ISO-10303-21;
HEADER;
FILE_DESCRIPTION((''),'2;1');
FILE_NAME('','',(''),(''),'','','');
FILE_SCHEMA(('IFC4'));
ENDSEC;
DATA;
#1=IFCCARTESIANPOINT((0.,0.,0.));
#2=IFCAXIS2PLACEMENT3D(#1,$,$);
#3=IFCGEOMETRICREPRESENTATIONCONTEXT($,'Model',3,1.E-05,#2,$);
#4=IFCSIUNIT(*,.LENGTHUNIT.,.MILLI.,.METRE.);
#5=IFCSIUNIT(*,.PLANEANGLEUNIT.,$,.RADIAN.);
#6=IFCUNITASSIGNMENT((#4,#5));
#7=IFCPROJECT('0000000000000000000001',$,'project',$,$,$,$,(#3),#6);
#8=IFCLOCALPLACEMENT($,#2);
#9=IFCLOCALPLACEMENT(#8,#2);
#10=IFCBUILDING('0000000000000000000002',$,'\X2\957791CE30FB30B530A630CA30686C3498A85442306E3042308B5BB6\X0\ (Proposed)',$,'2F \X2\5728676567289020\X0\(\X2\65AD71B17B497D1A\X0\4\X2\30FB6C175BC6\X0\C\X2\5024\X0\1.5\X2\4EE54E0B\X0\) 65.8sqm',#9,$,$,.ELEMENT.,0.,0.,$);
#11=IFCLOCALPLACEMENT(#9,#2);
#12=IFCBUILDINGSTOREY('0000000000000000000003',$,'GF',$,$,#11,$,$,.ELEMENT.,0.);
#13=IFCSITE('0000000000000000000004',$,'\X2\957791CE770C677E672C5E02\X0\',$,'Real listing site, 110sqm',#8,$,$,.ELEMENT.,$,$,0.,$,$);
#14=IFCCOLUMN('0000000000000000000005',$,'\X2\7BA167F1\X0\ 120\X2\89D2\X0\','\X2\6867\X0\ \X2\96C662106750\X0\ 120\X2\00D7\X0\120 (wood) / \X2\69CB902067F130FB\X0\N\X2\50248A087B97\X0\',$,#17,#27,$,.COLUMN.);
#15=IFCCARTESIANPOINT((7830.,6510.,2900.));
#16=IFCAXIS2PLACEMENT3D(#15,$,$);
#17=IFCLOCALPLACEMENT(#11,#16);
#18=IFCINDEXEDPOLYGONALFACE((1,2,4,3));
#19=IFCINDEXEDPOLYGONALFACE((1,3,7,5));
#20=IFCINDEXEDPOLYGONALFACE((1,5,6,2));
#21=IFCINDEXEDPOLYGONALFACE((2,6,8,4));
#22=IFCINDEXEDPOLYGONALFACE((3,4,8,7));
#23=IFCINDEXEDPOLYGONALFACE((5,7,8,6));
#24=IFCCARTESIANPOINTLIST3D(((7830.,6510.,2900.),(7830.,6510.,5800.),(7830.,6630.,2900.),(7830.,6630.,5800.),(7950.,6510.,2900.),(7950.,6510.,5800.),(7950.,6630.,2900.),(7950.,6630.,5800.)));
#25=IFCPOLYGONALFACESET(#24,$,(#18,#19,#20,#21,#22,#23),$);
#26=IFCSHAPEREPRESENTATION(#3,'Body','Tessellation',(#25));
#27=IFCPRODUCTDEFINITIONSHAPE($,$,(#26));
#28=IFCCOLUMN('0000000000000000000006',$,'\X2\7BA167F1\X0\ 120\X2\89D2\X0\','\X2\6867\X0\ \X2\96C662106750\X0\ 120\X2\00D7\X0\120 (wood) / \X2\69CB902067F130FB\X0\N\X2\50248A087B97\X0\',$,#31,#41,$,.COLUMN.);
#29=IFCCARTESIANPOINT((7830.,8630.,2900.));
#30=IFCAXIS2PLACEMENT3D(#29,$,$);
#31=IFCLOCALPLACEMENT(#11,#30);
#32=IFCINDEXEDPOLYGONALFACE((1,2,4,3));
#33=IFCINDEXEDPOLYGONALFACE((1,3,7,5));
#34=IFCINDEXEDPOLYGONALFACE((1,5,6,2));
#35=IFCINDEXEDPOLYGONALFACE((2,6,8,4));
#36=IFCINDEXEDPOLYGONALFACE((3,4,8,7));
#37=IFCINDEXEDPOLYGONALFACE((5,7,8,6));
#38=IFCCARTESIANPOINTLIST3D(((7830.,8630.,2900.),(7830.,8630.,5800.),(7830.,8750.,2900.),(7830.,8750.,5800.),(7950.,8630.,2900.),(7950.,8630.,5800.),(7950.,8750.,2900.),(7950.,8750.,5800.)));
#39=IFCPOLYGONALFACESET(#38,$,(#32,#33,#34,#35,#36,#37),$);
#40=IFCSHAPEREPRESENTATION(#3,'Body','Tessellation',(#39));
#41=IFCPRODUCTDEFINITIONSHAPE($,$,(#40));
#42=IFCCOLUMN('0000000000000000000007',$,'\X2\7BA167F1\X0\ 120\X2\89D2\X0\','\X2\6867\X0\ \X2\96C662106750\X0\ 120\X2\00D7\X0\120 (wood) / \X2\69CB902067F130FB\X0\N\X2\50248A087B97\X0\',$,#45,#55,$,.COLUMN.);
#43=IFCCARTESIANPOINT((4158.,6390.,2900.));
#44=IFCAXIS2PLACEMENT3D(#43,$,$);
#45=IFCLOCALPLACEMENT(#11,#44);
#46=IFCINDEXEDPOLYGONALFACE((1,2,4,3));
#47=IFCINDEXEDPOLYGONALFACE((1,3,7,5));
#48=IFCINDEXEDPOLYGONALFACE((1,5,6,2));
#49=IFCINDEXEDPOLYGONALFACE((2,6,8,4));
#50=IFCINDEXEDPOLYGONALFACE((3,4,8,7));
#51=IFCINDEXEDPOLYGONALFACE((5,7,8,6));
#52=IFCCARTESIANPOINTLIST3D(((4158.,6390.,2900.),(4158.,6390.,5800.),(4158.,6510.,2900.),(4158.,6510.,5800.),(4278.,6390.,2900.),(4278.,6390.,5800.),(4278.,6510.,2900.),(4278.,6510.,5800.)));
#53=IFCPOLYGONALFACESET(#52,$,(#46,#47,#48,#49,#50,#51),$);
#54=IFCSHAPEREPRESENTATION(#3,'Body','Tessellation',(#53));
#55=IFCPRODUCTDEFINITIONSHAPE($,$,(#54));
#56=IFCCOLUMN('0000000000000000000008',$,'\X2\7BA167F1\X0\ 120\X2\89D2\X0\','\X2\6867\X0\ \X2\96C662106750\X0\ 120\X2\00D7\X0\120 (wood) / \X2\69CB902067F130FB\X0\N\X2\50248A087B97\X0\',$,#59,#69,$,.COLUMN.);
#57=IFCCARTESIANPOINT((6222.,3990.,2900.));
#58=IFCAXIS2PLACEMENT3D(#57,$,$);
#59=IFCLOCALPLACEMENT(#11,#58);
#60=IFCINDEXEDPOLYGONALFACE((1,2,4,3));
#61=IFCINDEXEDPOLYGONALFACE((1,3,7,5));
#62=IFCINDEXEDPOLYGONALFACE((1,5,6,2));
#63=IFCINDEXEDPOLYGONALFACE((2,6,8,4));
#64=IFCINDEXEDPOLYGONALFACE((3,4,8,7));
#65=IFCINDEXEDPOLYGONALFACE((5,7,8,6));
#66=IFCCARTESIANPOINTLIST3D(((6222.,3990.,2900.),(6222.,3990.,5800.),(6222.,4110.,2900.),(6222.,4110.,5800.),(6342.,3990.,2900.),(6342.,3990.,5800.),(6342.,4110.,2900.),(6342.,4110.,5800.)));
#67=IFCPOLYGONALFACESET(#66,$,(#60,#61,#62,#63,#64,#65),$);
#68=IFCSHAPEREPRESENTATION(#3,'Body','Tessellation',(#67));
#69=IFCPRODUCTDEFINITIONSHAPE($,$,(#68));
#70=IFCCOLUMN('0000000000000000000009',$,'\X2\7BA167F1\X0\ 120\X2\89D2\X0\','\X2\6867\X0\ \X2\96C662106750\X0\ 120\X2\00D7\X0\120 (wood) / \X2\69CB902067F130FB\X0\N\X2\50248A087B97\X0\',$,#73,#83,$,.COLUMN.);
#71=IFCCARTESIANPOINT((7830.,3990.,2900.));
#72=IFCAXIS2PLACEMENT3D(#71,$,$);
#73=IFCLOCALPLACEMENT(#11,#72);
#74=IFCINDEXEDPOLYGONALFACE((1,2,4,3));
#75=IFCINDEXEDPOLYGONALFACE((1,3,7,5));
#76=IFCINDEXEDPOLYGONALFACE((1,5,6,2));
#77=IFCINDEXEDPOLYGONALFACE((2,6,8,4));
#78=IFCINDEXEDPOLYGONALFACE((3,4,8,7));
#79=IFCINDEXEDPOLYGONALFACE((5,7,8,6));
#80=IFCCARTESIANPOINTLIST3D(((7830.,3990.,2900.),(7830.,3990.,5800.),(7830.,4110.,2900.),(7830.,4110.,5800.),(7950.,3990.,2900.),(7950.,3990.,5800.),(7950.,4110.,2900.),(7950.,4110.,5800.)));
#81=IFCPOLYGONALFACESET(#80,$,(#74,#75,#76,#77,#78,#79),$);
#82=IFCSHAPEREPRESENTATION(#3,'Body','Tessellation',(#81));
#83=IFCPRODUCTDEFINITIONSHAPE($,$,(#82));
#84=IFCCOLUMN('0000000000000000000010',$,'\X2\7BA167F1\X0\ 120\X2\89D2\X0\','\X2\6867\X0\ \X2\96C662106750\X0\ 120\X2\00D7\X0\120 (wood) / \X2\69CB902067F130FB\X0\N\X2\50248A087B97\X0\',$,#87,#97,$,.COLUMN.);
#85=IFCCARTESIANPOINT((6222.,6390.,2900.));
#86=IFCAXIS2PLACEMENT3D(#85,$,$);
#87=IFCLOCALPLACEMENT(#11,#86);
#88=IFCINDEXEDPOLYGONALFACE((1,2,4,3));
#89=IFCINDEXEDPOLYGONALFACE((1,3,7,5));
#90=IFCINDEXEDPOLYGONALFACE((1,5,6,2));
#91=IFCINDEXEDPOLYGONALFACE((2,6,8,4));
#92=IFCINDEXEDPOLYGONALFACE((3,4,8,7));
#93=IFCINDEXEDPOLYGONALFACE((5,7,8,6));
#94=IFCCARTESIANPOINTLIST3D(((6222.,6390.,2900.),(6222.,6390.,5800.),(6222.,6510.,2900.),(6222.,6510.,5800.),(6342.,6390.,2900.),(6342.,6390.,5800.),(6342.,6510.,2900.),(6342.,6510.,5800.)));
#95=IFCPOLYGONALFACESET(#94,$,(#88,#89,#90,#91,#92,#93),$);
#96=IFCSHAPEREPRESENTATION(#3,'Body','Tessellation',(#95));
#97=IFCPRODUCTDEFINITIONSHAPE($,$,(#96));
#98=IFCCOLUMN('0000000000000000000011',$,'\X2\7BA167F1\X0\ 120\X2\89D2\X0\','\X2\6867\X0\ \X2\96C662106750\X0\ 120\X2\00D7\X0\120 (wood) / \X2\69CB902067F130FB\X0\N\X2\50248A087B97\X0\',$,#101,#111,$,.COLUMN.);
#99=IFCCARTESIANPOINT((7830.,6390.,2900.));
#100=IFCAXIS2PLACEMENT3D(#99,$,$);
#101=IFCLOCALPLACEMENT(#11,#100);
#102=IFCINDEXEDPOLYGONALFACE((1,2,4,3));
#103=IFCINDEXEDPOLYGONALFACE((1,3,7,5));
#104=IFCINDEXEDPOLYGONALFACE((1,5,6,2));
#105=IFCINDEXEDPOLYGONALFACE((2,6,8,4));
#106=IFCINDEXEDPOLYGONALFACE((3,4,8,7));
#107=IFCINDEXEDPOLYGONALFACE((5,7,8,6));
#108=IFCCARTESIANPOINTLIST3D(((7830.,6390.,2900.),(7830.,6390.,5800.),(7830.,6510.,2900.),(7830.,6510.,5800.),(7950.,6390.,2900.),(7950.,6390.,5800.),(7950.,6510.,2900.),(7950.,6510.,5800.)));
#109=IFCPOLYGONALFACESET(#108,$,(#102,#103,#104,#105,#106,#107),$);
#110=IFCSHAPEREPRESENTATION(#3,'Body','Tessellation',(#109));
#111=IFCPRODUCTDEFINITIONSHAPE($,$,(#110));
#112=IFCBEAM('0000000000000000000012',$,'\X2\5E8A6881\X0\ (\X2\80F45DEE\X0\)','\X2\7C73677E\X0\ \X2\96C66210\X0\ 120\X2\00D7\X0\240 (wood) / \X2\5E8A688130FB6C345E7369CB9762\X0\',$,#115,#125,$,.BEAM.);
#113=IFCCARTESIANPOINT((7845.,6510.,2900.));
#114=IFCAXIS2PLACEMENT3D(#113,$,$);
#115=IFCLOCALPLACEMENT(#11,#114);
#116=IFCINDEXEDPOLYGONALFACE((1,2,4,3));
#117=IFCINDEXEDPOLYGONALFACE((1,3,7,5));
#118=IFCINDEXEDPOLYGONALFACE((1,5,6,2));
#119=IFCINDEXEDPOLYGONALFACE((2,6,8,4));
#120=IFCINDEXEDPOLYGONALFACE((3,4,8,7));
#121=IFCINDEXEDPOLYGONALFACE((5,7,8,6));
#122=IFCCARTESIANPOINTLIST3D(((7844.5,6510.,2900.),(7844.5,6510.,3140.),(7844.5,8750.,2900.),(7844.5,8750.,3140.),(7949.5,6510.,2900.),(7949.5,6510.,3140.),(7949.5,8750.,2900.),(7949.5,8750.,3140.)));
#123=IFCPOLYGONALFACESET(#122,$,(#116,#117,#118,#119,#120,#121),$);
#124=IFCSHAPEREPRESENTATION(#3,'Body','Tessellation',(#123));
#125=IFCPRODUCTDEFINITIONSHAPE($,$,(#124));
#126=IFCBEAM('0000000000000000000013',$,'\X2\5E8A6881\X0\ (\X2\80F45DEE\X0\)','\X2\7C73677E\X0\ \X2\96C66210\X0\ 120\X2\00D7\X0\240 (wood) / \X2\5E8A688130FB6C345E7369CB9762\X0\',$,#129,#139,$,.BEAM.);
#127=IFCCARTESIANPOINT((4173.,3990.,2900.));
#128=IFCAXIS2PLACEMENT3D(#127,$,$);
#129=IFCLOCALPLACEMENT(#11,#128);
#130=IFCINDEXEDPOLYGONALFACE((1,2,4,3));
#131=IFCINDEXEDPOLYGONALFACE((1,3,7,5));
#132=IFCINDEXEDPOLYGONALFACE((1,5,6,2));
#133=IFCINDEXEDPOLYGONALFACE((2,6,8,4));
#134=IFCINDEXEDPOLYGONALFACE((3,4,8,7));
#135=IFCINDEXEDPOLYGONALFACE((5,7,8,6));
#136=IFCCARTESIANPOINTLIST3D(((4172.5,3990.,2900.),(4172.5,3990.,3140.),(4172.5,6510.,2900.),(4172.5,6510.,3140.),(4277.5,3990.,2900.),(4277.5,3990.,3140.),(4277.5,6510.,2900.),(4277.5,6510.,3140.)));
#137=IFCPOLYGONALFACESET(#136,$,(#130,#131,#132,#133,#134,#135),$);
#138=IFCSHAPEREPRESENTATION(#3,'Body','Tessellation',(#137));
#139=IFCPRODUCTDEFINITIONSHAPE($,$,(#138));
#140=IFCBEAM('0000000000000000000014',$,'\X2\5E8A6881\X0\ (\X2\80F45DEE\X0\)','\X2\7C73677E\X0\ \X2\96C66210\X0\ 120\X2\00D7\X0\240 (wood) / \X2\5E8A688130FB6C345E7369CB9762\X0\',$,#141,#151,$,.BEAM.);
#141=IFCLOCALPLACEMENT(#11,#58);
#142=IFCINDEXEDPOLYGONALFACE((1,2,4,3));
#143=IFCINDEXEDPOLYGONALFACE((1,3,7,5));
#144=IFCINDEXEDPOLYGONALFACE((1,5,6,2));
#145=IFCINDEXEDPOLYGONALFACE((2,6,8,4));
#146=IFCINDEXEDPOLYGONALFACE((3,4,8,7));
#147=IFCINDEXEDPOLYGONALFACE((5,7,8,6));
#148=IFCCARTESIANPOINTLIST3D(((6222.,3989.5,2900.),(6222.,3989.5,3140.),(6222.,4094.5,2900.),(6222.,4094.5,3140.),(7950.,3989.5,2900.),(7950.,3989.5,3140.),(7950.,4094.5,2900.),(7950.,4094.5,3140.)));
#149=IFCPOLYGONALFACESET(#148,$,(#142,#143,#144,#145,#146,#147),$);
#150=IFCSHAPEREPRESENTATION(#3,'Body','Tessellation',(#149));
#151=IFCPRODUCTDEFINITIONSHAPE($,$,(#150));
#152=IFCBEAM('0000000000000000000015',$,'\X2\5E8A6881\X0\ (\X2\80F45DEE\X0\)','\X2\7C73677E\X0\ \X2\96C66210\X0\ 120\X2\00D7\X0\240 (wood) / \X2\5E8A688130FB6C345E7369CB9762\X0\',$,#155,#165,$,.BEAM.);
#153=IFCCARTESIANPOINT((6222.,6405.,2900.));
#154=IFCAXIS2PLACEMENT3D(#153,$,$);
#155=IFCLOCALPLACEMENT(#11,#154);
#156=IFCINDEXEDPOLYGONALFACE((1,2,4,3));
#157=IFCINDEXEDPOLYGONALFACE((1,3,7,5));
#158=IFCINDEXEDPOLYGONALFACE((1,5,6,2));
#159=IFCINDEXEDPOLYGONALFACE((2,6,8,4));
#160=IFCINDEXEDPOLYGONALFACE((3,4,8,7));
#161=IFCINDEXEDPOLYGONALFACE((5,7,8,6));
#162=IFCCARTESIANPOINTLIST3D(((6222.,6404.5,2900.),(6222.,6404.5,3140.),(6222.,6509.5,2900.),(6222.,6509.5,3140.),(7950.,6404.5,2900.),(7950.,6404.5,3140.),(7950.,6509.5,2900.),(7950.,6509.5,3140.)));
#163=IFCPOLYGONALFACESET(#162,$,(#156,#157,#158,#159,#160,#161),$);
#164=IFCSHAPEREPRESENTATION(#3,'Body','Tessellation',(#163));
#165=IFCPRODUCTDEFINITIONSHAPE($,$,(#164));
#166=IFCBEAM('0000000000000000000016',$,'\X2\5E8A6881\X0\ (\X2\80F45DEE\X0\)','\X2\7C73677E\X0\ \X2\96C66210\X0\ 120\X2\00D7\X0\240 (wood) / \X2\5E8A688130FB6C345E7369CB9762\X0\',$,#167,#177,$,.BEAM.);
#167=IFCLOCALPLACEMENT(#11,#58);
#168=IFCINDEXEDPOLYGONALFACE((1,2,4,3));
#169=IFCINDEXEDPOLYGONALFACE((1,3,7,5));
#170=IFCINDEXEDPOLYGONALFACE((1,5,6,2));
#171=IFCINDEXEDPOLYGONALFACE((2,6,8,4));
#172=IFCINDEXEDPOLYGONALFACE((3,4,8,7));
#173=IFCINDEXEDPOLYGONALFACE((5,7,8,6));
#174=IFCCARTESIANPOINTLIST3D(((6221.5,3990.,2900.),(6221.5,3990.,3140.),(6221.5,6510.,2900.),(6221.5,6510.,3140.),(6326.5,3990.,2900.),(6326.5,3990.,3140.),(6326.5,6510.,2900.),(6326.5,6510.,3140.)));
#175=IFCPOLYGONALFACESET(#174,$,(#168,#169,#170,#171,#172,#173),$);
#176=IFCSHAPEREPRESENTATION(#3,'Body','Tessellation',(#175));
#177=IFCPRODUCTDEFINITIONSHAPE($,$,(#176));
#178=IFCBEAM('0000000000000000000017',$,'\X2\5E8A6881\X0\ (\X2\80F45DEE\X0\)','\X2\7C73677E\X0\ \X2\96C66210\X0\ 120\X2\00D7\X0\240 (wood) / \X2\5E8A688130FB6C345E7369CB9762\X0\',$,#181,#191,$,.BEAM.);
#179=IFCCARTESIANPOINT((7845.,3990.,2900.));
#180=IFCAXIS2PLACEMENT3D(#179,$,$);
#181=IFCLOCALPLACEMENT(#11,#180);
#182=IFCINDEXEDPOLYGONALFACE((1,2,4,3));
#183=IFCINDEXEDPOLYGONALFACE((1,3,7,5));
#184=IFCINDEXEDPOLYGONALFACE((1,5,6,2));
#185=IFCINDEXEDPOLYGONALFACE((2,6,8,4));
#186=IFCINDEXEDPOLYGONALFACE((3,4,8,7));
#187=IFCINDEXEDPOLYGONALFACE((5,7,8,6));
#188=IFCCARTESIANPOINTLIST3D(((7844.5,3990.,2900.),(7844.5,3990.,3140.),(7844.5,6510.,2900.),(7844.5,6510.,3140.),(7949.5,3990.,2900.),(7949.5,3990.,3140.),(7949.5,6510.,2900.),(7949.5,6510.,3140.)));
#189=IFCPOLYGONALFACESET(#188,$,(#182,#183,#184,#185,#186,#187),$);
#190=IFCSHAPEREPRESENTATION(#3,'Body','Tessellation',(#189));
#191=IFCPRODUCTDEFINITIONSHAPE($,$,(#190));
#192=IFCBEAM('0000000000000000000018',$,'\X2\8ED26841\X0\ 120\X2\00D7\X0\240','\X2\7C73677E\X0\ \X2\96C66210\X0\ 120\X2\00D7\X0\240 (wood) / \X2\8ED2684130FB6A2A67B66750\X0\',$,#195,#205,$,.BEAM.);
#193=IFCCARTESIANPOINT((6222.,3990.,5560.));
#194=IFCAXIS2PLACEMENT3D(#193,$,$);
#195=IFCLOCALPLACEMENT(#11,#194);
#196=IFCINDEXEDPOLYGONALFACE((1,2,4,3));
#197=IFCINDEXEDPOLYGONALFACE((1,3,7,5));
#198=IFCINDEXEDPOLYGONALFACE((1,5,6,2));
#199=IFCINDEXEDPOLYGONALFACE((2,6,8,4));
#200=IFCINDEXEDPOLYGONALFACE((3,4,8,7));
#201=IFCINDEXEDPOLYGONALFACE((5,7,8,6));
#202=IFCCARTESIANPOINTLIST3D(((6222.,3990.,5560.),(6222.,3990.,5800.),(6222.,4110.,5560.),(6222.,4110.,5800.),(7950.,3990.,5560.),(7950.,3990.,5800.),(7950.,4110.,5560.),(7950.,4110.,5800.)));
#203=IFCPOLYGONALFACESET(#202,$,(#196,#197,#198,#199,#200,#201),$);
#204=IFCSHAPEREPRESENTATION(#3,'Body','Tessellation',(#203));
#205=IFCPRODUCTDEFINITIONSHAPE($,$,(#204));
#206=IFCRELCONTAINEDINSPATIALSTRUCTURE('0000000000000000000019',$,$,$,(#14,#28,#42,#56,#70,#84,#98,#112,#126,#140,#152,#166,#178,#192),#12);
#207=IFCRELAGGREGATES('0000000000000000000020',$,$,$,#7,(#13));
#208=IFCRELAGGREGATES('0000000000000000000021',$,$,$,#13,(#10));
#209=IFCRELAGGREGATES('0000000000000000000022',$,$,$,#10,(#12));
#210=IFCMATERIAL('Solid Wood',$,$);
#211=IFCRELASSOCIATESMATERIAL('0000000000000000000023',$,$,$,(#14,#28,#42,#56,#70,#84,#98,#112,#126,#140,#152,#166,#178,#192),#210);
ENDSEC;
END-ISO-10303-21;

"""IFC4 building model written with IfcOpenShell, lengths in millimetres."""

from ifc_helpers import new_model, si_unit, frame, frame_2d, origin, place, context, project, spatial, rectangle, extrude, material, element, save


model = new_model("IFC4")

# Units and contexts
model_context = context("Model", 3, precision=1e-05, world=origin())
ifc_project = project(units=[si_unit("LENGTHUNIT", "METRE", prefix="MILLI"), si_unit("PLANEANGLEUNIT", "RADIAN")], contexts=[model_context])

# Site, building, storey
site_placement = place(None, origin())
site = spatial("IfcSite", under=ifc_project, at=site_placement, Name="長野県松本市", ObjectType="Real listing site, 110sqm", CompositionType="ELEMENT", RefElevation=0.0)
building_placement = place(site_placement, origin())
building = spatial("IfcBuilding", under=site, at=building_placement, Name="長野・サウナと水風呂のある家 (Proposed)", ObjectType="2F 在来木造(断熱等級4・気密C値1.5以下) 65.8sqm", CompositionType="ELEMENT", ElevationOfRefHeight=0.0, ElevationOfTerrain=0.0)
storey_placement = place(building_placement, origin())
storey = spatial("IfcBuildingStorey", under=building, at=storey_placement, Name="GF", CompositionType="ELEMENT", Elevation=0.0)

# Columns
ifc_material_1 = material(Name="Solid Wood")
column_1_placement = place(storey_placement, frame((7830.0, 6510.0, 2900.0)))
element("IfcColumn", 1, at=column_1_placement, inside=storey, material=ifc_material_1, Name="管柱 120角", Description="桧 集成材 120×120 (wood) / 構造柱・N値計算", PredefinedType="COLUMN", context=model_context, shape_type="SweptSolid", body=[
    extrude(rectangle(XDim=120.0, YDim=120.0, at=frame_2d((60.0, 60.0))), frame((7830.0, 6510.0, 2900.0)), (0.0, 0.0, 1.0), 2900.0),
])
column_2_placement = place(storey_placement, frame((7830.0, 8630.0, 2900.0)))
element("IfcColumn", 2, at=column_2_placement, inside=storey, material=ifc_material_1, Name="管柱 120角", Description="桧 集成材 120×120 (wood) / 構造柱・N値計算", PredefinedType="COLUMN", context=model_context, shape_type="SweptSolid", body=[
    extrude(rectangle(XDim=120.0, YDim=120.0, at=frame_2d((60.0, 60.0))), frame((7830.0, 8630.0, 2900.0)), (0.0, 0.0, 1.0), 2900.0),
])
column_3_placement = place(storey_placement, frame((4158.0, 6390.0, 2900.0)))
element("IfcColumn", 3, at=column_3_placement, inside=storey, material=ifc_material_1, Name="管柱 120角", Description="桧 集成材 120×120 (wood) / 構造柱・N値計算", PredefinedType="COLUMN", context=model_context, shape_type="SweptSolid", body=[
    extrude(rectangle(XDim=120.0, YDim=120.0, at=frame_2d((60.0, 60.0))), frame((4158.0, 6390.0, 2900.0)), (0.0, 0.0, 1.0), 2900.0),
])
column_4_placement = place(storey_placement, frame((6222.0, 3990.0, 2900.0)))
element("IfcColumn", 4, at=column_4_placement, inside=storey, material=ifc_material_1, Name="管柱 120角", Description="桧 集成材 120×120 (wood) / 構造柱・N値計算", PredefinedType="COLUMN", context=model_context, shape_type="SweptSolid", body=[
    extrude(rectangle(XDim=120.0, YDim=120.0, at=frame_2d((60.0, 60.0))), frame((6222.0, 3990.0, 2900.0)), (0.0, 0.0, 1.0), 2900.0),
])
column_5_placement = place(storey_placement, frame((7830.0, 3990.0, 2900.0)))
element("IfcColumn", 5, at=column_5_placement, inside=storey, material=ifc_material_1, Name="管柱 120角", Description="桧 集成材 120×120 (wood) / 構造柱・N値計算", PredefinedType="COLUMN", context=model_context, shape_type="SweptSolid", body=[
    extrude(rectangle(XDim=120.0, YDim=120.0, at=frame_2d((60.0, 60.0))), frame((7830.0, 3990.0, 2900.0)), (0.0, 0.0, 1.0), 2900.0),
])
column_6_placement = place(storey_placement, frame((6222.0, 6390.0, 2900.0)))
element("IfcColumn", 6, at=column_6_placement, inside=storey, material=ifc_material_1, Name="管柱 120角", Description="桧 集成材 120×120 (wood) / 構造柱・N値計算", PredefinedType="COLUMN", context=model_context, shape_type="SweptSolid", body=[
    extrude(rectangle(XDim=120.0, YDim=120.0, at=frame_2d((60.0, 60.0))), frame((6222.0, 6390.0, 2900.0)), (0.0, 0.0, 1.0), 2900.0),
])
column_7_placement = place(storey_placement, frame((7830.0, 6390.0, 2900.0)))
element("IfcColumn", 7, at=column_7_placement, inside=storey, material=ifc_material_1, Name="管柱 120角", Description="桧 集成材 120×120 (wood) / 構造柱・N値計算", PredefinedType="COLUMN", context=model_context, shape_type="SweptSolid", body=[
    extrude(rectangle(XDim=120.0, YDim=120.0, at=frame_2d((60.0, 60.0))), frame((7830.0, 6390.0, 2900.0)), (0.0, 0.0, 1.0), 2900.0),
])

# Beams
beam_1_placement = place(storey_placement, frame((7845.0, 6510.0, 2900.0)))
element("IfcBeam", 8, at=beam_1_placement, inside=storey, material=ifc_material_1, Name="床梁 (胴差)", Description="米松 集成 120×240 (wood) / 床梁・水平構面", PredefinedType="BEAM", context=model_context, shape_type="SweptSolid", body=[
    extrude(rectangle(XDim=105.0, YDim=2240.0, at=frame_2d((52.0, 1120.0))), frame((7845.0, 6510.0, 2900.0)), (0.0, 0.0, 1.0), 240.0),
])
beam_2_placement = place(storey_placement, frame((4173.0, 3990.0, 2900.0)))
element("IfcBeam", 9, at=beam_2_placement, inside=storey, material=ifc_material_1, Name="床梁 (胴差)", Description="米松 集成 120×240 (wood) / 床梁・水平構面", PredefinedType="BEAM", context=model_context, shape_type="SweptSolid", body=[
    extrude(rectangle(XDim=105.0, YDim=2520.0, at=frame_2d((52.0, 1260.0))), frame((4173.0, 3990.0, 2900.0)), (0.0, 0.0, 1.0), 240.0),
])
beam_3_placement = place(storey_placement, frame((6222.0, 3990.0, 2900.0)))
element("IfcBeam", 10, at=beam_3_placement, inside=storey, material=ifc_material_1, Name="床梁 (胴差)", Description="米松 集成 120×240 (wood) / 床梁・水平構面", PredefinedType="BEAM", context=model_context, shape_type="SweptSolid", body=[
    extrude(rectangle(XDim=1728.0, YDim=105.0, at=frame_2d((864.0, 52.0))), frame((6222.0, 3990.0, 2900.0)), (0.0, 0.0, 1.0), 240.0),
])
beam_4_placement = place(storey_placement, frame((6222.0, 6405.0, 2900.0)))
element("IfcBeam", 11, at=beam_4_placement, inside=storey, material=ifc_material_1, Name="床梁 (胴差)", Description="米松 集成 120×240 (wood) / 床梁・水平構面", PredefinedType="BEAM", context=model_context, shape_type="SweptSolid", body=[
    extrude(rectangle(XDim=1728.0, YDim=105.0, at=frame_2d((864.0, 52.0))), frame((6222.0, 6405.0, 2900.0)), (0.0, 0.0, 1.0), 240.0),
])
beam_5_placement = place(storey_placement, frame((6222.0, 3990.0, 2900.0)))
element("IfcBeam", 12, at=beam_5_placement, inside=storey, material=ifc_material_1, Name="床梁 (胴差)", Description="米松 集成 120×240 (wood) / 床梁・水平構面", PredefinedType="BEAM", context=model_context, shape_type="SweptSolid", body=[
    extrude(rectangle(XDim=105.0, YDim=2520.0, at=frame_2d((52.0, 1260.0))), frame((6222.0, 3990.0, 2900.0)), (0.0, 0.0, 1.0), 240.0),
])
beam_6_placement = place(storey_placement, frame((7845.0, 3990.0, 2900.0)))
element("IfcBeam", 13, at=beam_6_placement, inside=storey, material=ifc_material_1, Name="床梁 (胴差)", Description="米松 集成 120×240 (wood) / 床梁・水平構面", PredefinedType="BEAM", context=model_context, shape_type="SweptSolid", body=[
    extrude(rectangle(XDim=105.0, YDim=2520.0, at=frame_2d((52.0, 1260.0))), frame((7845.0, 3990.0, 2900.0)), (0.0, 0.0, 1.0), 240.0),
])
beam_7_placement = place(storey_placement, frame((6222.0, 3990.0, 5560.0)))
element("IfcBeam", 14, at=beam_7_placement, inside=storey, material=ifc_material_1, Name="軒桁 120×240", Description="米松 集成 120×240 (wood) / 軒桁・横架材", PredefinedType="BEAM", context=model_context, shape_type="SweptSolid", body=[
    extrude(rectangle(XDim=1728.0, YDim=120.0, at=frame_2d((864.0, 60.0))), frame((6222.0, 3990.0, 5560.0)), (0.0, 0.0, 1.0), 240.0),
])

save(model, "model.ifc")
